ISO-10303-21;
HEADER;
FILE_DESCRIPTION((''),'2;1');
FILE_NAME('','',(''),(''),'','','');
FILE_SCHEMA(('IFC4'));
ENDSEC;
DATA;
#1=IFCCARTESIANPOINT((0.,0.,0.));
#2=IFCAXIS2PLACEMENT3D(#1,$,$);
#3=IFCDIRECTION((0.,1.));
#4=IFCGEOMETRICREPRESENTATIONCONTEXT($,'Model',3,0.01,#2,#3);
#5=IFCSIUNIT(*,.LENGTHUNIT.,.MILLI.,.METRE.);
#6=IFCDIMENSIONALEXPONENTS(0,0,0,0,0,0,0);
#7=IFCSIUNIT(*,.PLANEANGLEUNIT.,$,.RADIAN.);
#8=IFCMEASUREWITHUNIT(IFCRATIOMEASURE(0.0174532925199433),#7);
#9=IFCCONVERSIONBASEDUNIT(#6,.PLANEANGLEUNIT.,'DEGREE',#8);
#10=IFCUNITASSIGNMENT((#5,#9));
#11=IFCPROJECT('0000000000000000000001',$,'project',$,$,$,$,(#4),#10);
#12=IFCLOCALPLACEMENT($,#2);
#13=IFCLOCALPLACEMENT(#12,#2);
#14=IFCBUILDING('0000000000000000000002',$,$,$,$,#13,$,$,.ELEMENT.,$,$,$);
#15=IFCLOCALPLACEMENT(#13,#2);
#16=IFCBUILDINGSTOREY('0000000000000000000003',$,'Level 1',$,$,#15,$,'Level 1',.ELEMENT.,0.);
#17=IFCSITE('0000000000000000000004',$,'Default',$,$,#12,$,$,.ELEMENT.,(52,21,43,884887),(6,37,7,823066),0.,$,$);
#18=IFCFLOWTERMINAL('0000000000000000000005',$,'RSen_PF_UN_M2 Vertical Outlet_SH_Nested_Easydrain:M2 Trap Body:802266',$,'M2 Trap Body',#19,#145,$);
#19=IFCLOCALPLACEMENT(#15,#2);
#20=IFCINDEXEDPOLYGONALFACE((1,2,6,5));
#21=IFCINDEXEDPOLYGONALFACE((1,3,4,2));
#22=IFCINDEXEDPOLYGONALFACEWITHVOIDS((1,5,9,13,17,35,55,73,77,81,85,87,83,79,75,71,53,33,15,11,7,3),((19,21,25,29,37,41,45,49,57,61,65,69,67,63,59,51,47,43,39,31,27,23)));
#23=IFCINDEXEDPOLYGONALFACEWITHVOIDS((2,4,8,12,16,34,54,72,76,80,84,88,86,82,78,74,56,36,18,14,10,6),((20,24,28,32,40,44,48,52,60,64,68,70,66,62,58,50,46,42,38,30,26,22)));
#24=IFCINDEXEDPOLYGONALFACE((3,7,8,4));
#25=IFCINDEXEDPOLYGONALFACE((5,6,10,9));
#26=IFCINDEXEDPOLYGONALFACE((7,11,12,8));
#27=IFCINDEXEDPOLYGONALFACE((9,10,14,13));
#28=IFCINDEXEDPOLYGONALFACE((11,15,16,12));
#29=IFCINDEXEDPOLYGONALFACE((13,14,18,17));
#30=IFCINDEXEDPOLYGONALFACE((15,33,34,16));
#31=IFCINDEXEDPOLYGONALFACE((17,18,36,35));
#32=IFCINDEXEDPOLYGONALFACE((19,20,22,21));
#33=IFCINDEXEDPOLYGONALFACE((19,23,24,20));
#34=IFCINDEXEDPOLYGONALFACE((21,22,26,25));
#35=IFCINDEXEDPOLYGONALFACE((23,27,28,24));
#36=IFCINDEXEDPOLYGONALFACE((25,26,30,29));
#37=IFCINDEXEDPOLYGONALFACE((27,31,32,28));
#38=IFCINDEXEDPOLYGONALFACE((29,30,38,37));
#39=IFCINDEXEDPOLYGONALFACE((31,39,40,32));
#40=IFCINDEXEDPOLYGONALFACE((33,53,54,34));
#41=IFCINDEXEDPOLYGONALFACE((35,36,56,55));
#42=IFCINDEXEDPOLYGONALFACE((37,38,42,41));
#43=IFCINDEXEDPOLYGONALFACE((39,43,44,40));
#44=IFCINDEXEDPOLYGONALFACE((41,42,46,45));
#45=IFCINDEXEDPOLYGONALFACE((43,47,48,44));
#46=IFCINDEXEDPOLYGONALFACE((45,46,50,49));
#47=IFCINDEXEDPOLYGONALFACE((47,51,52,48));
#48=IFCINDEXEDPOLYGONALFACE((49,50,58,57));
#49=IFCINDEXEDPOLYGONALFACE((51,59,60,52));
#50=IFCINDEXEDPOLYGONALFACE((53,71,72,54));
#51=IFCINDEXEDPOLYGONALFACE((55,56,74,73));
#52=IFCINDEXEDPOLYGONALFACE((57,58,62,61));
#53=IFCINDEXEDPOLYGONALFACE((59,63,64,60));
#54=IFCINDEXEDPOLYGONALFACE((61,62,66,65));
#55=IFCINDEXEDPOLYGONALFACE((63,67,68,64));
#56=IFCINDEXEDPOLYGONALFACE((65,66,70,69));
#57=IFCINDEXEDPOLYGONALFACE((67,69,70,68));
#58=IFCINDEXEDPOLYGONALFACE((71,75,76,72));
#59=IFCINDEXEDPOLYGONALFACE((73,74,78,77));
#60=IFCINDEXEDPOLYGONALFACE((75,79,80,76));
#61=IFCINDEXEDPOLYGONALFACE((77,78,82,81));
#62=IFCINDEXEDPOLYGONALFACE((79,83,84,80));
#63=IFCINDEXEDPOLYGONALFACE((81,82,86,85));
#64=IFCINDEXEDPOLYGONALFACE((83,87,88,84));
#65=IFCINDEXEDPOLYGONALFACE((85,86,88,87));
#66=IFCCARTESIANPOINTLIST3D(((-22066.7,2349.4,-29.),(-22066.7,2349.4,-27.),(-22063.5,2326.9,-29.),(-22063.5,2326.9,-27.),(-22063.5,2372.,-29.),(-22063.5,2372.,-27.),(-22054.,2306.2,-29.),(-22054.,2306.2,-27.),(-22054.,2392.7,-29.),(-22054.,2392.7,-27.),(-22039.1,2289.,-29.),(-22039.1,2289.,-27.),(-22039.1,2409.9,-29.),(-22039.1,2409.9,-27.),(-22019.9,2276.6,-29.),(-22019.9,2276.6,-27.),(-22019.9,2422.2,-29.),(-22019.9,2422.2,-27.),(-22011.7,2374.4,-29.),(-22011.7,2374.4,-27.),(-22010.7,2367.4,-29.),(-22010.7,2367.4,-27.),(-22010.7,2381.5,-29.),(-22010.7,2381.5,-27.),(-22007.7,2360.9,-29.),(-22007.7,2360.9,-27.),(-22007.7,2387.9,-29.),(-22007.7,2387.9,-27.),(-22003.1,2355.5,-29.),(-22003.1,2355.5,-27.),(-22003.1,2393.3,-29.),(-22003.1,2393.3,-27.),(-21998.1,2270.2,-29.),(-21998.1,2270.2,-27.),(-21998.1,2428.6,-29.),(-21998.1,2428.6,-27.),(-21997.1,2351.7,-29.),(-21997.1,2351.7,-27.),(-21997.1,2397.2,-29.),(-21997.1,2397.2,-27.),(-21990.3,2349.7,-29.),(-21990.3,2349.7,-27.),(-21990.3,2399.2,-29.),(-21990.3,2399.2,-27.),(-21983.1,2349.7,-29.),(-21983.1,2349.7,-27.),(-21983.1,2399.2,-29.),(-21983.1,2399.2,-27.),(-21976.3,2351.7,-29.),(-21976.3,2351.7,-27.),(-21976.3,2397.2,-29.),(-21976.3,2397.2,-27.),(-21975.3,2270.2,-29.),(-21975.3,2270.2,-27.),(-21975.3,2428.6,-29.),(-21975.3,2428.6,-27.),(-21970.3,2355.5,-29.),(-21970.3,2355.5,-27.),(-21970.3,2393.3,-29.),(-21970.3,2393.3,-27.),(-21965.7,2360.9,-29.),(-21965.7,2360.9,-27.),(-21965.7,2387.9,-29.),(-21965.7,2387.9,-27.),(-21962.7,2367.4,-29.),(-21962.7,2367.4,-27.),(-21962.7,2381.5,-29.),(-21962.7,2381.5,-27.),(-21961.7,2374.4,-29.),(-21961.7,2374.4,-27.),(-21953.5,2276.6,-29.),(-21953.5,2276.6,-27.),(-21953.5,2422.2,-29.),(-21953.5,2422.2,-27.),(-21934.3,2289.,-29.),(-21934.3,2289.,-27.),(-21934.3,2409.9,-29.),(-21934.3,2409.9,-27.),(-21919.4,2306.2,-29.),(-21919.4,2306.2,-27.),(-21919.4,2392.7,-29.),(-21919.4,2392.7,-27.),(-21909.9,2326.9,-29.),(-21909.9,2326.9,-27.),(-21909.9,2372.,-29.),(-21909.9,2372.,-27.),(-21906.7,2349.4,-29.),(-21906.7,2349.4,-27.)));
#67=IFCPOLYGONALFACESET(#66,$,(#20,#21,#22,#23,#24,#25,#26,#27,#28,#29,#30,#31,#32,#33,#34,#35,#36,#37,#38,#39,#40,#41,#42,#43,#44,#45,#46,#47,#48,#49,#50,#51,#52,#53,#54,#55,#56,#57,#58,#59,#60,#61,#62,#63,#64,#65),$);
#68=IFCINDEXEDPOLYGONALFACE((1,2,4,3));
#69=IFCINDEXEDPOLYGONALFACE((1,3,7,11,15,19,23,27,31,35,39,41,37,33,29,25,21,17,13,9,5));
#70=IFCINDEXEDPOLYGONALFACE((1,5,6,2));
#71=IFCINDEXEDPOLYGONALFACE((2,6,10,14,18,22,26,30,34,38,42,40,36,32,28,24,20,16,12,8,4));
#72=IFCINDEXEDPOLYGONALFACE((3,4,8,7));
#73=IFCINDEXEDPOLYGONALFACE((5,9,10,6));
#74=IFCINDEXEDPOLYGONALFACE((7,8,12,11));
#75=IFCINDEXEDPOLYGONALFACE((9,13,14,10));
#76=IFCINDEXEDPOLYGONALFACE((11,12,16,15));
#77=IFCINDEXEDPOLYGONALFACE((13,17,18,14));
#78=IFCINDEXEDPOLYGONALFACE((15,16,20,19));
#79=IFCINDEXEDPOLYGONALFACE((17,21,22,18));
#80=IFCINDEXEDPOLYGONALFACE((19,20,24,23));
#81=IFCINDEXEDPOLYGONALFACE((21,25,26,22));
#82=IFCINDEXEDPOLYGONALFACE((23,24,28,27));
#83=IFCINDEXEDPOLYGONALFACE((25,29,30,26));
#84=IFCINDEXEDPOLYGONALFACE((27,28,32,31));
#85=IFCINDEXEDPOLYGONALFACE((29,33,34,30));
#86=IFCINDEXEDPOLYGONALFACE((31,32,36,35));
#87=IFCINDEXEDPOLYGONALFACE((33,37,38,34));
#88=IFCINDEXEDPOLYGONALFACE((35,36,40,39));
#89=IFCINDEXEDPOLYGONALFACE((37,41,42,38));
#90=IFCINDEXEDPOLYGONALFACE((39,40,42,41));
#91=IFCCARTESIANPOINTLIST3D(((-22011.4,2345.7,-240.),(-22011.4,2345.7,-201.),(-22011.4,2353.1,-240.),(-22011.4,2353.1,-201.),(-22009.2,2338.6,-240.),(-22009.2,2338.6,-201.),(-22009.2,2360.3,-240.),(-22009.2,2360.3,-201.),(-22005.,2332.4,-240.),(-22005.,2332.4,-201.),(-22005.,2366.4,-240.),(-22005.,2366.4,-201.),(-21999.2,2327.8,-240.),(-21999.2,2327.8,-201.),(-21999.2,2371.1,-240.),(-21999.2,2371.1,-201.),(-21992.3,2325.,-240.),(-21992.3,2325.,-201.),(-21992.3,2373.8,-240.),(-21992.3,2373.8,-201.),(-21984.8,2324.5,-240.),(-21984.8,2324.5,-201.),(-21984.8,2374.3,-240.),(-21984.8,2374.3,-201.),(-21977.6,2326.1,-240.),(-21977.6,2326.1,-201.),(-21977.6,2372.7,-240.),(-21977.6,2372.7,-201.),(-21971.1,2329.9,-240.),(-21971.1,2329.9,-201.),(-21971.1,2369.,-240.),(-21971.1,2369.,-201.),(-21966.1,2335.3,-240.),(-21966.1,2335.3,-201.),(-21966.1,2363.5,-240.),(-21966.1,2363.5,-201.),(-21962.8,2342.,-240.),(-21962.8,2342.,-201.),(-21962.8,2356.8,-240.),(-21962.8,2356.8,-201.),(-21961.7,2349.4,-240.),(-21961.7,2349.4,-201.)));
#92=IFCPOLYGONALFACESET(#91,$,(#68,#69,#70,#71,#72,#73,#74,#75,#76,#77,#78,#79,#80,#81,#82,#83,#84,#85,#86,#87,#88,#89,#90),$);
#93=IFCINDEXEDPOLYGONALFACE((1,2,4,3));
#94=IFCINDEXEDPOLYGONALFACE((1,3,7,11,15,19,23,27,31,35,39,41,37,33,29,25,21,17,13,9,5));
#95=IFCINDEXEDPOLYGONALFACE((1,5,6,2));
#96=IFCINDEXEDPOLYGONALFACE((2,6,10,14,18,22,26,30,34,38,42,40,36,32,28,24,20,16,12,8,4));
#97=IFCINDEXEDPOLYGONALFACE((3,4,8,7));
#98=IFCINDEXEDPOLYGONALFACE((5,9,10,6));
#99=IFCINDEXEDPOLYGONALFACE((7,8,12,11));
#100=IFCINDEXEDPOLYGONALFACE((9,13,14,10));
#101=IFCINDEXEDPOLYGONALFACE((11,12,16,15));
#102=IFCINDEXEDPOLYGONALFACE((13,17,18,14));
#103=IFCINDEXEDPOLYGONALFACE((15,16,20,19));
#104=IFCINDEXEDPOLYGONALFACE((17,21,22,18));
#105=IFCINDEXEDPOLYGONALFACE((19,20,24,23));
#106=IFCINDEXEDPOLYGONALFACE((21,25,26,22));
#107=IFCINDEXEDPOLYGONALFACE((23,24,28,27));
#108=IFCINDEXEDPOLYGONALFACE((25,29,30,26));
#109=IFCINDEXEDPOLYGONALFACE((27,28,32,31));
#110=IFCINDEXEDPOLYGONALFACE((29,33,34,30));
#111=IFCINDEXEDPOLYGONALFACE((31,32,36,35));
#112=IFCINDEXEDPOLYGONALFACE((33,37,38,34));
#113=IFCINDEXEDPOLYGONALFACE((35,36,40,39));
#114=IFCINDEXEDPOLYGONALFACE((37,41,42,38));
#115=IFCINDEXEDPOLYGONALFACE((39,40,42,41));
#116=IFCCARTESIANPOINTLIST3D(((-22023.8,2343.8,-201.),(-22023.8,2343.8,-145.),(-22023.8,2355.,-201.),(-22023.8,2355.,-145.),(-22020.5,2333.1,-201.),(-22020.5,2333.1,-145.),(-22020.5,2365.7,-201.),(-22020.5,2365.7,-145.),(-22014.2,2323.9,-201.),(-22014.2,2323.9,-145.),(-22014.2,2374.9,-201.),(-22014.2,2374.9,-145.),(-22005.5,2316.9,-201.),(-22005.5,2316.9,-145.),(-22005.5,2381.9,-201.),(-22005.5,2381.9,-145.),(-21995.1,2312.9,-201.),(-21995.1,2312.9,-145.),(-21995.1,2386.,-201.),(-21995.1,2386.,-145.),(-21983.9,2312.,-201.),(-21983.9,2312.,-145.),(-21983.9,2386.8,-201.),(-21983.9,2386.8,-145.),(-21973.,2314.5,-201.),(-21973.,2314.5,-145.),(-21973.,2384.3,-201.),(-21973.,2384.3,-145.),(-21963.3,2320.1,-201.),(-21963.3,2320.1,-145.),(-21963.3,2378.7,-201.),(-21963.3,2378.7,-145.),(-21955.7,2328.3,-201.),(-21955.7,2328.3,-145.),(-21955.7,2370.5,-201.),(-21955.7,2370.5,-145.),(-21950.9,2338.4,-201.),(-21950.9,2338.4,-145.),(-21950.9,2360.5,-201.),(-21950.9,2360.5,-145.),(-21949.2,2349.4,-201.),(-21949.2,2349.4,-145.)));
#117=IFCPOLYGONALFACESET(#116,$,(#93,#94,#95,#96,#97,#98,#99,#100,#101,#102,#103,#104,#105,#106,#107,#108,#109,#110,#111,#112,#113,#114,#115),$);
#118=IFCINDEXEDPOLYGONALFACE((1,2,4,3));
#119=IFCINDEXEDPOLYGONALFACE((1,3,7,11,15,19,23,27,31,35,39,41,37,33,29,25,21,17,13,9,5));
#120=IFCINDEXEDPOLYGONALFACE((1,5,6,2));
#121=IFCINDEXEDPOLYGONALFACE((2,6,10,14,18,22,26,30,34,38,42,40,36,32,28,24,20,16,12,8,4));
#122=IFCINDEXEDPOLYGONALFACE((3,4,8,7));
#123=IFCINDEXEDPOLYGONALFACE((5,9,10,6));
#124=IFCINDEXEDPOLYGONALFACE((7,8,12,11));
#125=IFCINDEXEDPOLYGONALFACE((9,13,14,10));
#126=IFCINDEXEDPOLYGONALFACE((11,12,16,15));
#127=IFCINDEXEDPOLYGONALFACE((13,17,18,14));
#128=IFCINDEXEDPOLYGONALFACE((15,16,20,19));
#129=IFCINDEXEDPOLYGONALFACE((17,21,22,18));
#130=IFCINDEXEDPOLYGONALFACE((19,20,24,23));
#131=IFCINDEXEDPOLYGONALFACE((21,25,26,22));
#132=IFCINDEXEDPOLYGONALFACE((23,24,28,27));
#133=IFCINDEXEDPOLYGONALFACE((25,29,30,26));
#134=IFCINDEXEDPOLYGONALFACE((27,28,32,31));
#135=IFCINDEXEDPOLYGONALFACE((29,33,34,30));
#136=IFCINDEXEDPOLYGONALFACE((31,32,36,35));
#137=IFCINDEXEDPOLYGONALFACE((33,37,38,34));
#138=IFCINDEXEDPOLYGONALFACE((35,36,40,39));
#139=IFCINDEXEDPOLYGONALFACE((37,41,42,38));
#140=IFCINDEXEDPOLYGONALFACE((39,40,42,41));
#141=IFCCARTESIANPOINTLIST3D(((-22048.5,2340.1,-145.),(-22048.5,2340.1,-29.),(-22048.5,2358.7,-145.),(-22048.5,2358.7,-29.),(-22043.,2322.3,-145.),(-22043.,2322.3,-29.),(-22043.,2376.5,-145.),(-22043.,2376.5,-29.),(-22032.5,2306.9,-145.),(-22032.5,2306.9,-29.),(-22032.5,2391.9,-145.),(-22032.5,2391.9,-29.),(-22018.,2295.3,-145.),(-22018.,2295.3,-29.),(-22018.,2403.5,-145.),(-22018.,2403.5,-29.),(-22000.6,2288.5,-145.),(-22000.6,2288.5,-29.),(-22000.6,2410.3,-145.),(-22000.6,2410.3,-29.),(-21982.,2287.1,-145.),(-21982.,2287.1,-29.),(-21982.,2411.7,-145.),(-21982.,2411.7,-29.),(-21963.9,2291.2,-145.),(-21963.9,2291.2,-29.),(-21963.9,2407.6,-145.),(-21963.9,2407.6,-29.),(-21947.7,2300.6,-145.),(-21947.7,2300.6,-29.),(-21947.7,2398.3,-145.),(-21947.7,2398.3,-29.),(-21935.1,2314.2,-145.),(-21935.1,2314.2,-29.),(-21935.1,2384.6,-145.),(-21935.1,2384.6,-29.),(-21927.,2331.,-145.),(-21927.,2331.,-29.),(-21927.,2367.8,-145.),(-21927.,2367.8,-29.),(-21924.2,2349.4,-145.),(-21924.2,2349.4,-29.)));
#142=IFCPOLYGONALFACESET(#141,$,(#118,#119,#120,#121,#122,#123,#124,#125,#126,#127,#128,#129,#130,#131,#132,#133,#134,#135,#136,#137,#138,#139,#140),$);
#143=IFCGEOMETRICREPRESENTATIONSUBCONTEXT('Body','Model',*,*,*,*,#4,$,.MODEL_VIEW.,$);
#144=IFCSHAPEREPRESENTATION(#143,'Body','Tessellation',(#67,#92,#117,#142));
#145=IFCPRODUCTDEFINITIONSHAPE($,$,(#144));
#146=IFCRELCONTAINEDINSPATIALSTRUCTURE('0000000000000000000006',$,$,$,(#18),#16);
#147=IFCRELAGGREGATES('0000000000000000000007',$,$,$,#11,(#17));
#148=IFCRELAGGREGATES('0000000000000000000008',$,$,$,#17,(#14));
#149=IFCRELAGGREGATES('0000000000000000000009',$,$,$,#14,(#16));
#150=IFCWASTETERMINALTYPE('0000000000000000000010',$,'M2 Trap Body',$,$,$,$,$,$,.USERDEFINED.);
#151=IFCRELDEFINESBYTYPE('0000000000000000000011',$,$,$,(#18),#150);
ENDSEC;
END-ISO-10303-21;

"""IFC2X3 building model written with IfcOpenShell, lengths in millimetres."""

from ifc_helpers import new_model, entity, si_unit, converted_unit, direction, frame, frame_2d, origin, origin_2d_with_axis, place, context, subcontext, project, spatial, circle_curve, parameter, trimmed, segment, composite_curve, circle, outline, extrude, source, transform, mapped, type_object, type_shapes, element, save


model = new_model("IFC2X3")

# Units and contexts
model_context = context("Model", 3, precision=0.01, world=origin(), true_north=direction((0.0, 1.0)))
body_context = subcontext(model_context, "Body", "Model", "MODEL_VIEW")
ifc_project = project(units=[si_unit("LENGTHUNIT", "METRE", prefix="MILLI"), converted_unit("PLANEANGLEUNIT", "DEGREE", entity("IfcRatioMeasure", 0.0174532925199433), si_unit("PLANEANGLEUNIT", "RADIAN"), dimensions=[0, 0, 0, 0, 0, 0, 0])], contexts=[model_context])

# Site, building, storey
site_placement = place(None, origin())
site = spatial("IfcSite", under=ifc_project, at=site_placement, Name="Default", CompositionType="ELEMENT", RefLatitude=(52, 21, 43, 884887), RefLongitude=(6, 37, 7, 823066), RefElevation=0.0)
building_placement = place(site_placement, origin())
building = spatial("IfcBuilding", under=site, at=building_placement, CompositionType="ELEMENT")
storey_placement = place(building_placement, origin())
storey = spatial("IfcBuildingStorey", under=building, at=storey_placement, Name="Level 1", LongName="Level 1", CompositionType="ELEMENT", Elevation=0.0)

# Flow terminal
waste_terminal_type_1 = type_object("IfcWasteTerminalType", Name="M2 Trap Body", PredefinedType="USERDEFINED")
shared_shape_1 = source(origin(), body_context, "Body", "SweptSolid", [
    extrude(outline(composite_curve([segment(trimmed(circle_curve(origin_2d_with_axis(), 80.0), [parameter(0.0)], [parameter(180.0)], True, "PARAMETER"), True, "CONTINUOUS"), segment(trimmed(circle_curve(origin_2d_with_axis(), 80.0), [parameter(180.0)], [parameter(360.0)], True, "PARAMETER"), True, "CONTINUOUS")], self_intersect=False), holes=[composite_curve([segment(trimmed(circle_curve(frame_2d((0.0, 25.0), x_axis=(1.0, 0.0)), 25.0), [parameter(180.0)], [parameter(360.0)], True, "PARAMETER"), False, "CONTINUOUS"), segment(trimmed(circle_curve(frame_2d((0.0, 25.0), x_axis=(1.0, 0.0)), 25.0), [parameter(0.0)], [parameter(180.0)], True, "PARAMETER"), False, "CONTINUOUS")], self_intersect=False)]), frame((0.0, -25.0, -2.0)), (0.0, 0.0, 1.0), 2.0),
    extrude(circle(Radius=25.0, at=frame_2d((0.0, 0.0), x_axis=(1.0, 0.0))), frame((0.0, -25.0, -213.0)), (0.0, 0.0, 1.0), 39.0),
    extrude(circle(Radius=37.5, at=frame_2d((0.0, 0.0), x_axis=(1.0, 0.0))), frame((0.0, -25.0, -174.0)), (0.0, 0.0, 1.0), 56.0),
    extrude(circle(Radius=62.5, at=frame_2d((0.0, 0.0), x_axis=(1.0, 0.0))), frame((0.0, -25.0, -118.0)), (0.0, 0.0, 1.0), 116.0),
])
type_shapes(waste_terminal_type_1, [shared_shape_1])
for number, where, name in (
    (1, (-21986.7, 2374.4, -27.0), "RSen_PF_UN_M2 Vertical Outlet_SH_Nested_Easydrain:M2 Trap Body:802266"),
):
    element("IfcFlowTerminal", number, at=place(storey_placement, frame(where)), inside=storey, type_object=waste_terminal_type_1, Name=name, ObjectType="M2 Trap Body", context=body_context, shape_type="MappedRepresentation", body=[
        mapped(shared_shape_1, transform((0.0, 0.0, 0.0), scale=1.0)),
    ])

save(model, "model.ifc")
